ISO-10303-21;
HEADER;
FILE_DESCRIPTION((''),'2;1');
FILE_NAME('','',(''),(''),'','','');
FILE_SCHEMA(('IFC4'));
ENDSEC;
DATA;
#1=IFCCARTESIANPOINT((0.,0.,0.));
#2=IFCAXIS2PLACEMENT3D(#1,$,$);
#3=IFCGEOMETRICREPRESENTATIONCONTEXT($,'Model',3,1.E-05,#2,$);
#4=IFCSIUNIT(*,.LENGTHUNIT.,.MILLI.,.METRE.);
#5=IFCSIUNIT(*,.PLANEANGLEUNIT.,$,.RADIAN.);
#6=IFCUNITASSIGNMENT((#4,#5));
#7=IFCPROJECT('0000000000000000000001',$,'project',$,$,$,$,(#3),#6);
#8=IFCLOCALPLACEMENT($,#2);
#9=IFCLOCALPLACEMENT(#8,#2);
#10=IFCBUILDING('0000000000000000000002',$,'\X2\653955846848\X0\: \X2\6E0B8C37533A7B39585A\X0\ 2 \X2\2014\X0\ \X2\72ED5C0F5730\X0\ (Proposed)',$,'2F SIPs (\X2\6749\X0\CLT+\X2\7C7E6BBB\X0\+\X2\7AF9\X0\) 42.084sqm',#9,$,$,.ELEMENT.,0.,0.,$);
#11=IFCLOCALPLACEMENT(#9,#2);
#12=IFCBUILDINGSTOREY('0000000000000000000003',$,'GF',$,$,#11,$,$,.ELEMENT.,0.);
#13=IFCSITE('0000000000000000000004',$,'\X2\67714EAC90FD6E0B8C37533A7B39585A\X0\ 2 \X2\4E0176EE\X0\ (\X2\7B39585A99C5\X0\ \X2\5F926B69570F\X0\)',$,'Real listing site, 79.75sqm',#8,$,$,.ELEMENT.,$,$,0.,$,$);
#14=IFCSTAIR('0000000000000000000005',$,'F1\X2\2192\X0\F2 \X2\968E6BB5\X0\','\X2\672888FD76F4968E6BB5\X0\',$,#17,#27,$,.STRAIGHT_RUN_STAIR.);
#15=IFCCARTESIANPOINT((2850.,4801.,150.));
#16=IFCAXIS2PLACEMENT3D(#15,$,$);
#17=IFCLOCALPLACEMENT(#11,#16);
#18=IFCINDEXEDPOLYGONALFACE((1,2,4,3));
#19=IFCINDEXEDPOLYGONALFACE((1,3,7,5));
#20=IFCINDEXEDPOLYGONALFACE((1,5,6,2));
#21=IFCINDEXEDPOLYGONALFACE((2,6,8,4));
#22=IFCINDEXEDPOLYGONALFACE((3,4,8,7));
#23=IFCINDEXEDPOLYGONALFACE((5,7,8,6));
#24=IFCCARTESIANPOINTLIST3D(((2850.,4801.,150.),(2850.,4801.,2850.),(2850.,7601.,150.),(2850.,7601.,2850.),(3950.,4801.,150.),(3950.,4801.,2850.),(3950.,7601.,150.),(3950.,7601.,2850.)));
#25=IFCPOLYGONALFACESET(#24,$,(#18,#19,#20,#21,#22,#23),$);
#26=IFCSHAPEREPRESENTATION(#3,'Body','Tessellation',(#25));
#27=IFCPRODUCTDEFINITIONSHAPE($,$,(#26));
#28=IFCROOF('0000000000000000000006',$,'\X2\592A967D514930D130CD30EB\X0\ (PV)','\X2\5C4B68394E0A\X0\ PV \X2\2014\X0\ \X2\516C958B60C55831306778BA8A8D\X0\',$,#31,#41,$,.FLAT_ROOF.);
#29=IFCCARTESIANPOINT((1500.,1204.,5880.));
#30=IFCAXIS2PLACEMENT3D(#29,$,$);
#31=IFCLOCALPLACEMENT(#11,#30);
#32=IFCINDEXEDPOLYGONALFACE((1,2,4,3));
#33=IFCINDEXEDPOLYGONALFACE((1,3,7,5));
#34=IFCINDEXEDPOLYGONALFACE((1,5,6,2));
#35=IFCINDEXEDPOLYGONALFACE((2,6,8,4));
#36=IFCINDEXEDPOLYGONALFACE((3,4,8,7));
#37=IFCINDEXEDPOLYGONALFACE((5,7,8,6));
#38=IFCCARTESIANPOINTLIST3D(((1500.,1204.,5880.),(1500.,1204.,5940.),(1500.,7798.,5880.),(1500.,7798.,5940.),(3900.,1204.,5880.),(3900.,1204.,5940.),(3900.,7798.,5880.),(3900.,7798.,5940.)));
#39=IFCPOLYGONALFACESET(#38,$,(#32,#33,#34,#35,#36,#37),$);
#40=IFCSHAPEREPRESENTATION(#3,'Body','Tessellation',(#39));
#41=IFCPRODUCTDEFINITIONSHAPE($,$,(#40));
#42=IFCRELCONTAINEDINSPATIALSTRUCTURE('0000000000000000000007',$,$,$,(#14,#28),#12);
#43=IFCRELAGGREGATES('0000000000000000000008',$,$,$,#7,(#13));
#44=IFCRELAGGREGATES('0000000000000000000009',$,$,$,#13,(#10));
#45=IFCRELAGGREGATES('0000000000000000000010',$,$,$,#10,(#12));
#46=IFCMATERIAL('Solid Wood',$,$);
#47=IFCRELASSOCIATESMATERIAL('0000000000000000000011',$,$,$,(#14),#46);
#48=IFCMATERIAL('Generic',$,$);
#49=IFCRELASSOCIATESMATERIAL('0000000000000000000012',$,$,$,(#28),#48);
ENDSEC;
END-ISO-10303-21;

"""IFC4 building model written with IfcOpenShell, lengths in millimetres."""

from ifc_helpers import new_model, si_unit, frame, frame_2d, origin, place, context, project, spatial, rectangle, extrude, material, element, save


model = new_model("IFC4")

# Units and contexts
model_context = context("Model", 3, precision=1e-05, world=origin())
ifc_project = project(units=[si_unit("LENGTHUNIT", "METRE", prefix="MILLI"), si_unit("PLANEANGLEUNIT", "RADIAN")], contexts=[model_context])

# Site, building, storey
site_placement = place(None, origin())
site = spatial("IfcSite", under=ifc_project, at=site_placement, Name="東京都渋谷区笹塚 2 丁目 (笹塚駅 徒歩圏)", ObjectType="Real listing site, 79.75sqm", CompositionType="ELEMENT", RefElevation=0.0)
building_placement = place(site_placement, origin())
building = spatial("IfcBuilding", under=site, at=building_placement, Name="改善案: 渋谷区笹塚 2 — 狭小地 (Proposed)", ObjectType="2F SIPs (杉CLT+籾殻+竹) 42.084sqm", CompositionType="ELEMENT", ElevationOfRefHeight=0.0, ElevationOfTerrain=0.0)
storey_placement = place(building_placement, origin())
storey = spatial("IfcBuildingStorey", under=building, at=storey_placement, Name="GF", CompositionType="ELEMENT", Elevation=0.0)

# Shared definitions
ifc_material_1 = material(Name="Generic")

# Stair
ifc_material_2 = material(Name="Solid Wood")
stair_placement = place(storey_placement, frame((2850.0, 4801.0, 150.0)))
element("IfcStair", 1, at=stair_placement, inside=storey, material=ifc_material_2, Name="F1→F2 階段", Description="木製直階段", PredefinedType="STRAIGHT_RUN_STAIR", context=model_context, shape_type="SweptSolid", body=[
    extrude(rectangle(XDim=1100.0, YDim=2800.0, at=frame_2d((550.0, 1400.0))), frame((2850.0, 4801.0, 150.0)), (0.0, 0.0, 1.0), 2700.0),
])

# Roof
roof_placement = place(storey_placement, frame((1500.0, 1204.0, 5880.0)))
element("IfcRoof", 2, at=roof_placement, inside=storey, material=ifc_material_1, Name="太陽光パネル (PV)", Description="屋根上 PV — 公開情報で確認", PredefinedType="FLAT_ROOF", context=model_context, shape_type="SweptSolid", body=[
    extrude(rectangle(XDim=2400.0, YDim=6594.0, at=frame_2d((1200.0, 3297.0))), frame((1500.0, 1204.0, 5880.0)), (0.0, 0.0, 1.0), 60.0),
])

save(model, "model.ifc")
